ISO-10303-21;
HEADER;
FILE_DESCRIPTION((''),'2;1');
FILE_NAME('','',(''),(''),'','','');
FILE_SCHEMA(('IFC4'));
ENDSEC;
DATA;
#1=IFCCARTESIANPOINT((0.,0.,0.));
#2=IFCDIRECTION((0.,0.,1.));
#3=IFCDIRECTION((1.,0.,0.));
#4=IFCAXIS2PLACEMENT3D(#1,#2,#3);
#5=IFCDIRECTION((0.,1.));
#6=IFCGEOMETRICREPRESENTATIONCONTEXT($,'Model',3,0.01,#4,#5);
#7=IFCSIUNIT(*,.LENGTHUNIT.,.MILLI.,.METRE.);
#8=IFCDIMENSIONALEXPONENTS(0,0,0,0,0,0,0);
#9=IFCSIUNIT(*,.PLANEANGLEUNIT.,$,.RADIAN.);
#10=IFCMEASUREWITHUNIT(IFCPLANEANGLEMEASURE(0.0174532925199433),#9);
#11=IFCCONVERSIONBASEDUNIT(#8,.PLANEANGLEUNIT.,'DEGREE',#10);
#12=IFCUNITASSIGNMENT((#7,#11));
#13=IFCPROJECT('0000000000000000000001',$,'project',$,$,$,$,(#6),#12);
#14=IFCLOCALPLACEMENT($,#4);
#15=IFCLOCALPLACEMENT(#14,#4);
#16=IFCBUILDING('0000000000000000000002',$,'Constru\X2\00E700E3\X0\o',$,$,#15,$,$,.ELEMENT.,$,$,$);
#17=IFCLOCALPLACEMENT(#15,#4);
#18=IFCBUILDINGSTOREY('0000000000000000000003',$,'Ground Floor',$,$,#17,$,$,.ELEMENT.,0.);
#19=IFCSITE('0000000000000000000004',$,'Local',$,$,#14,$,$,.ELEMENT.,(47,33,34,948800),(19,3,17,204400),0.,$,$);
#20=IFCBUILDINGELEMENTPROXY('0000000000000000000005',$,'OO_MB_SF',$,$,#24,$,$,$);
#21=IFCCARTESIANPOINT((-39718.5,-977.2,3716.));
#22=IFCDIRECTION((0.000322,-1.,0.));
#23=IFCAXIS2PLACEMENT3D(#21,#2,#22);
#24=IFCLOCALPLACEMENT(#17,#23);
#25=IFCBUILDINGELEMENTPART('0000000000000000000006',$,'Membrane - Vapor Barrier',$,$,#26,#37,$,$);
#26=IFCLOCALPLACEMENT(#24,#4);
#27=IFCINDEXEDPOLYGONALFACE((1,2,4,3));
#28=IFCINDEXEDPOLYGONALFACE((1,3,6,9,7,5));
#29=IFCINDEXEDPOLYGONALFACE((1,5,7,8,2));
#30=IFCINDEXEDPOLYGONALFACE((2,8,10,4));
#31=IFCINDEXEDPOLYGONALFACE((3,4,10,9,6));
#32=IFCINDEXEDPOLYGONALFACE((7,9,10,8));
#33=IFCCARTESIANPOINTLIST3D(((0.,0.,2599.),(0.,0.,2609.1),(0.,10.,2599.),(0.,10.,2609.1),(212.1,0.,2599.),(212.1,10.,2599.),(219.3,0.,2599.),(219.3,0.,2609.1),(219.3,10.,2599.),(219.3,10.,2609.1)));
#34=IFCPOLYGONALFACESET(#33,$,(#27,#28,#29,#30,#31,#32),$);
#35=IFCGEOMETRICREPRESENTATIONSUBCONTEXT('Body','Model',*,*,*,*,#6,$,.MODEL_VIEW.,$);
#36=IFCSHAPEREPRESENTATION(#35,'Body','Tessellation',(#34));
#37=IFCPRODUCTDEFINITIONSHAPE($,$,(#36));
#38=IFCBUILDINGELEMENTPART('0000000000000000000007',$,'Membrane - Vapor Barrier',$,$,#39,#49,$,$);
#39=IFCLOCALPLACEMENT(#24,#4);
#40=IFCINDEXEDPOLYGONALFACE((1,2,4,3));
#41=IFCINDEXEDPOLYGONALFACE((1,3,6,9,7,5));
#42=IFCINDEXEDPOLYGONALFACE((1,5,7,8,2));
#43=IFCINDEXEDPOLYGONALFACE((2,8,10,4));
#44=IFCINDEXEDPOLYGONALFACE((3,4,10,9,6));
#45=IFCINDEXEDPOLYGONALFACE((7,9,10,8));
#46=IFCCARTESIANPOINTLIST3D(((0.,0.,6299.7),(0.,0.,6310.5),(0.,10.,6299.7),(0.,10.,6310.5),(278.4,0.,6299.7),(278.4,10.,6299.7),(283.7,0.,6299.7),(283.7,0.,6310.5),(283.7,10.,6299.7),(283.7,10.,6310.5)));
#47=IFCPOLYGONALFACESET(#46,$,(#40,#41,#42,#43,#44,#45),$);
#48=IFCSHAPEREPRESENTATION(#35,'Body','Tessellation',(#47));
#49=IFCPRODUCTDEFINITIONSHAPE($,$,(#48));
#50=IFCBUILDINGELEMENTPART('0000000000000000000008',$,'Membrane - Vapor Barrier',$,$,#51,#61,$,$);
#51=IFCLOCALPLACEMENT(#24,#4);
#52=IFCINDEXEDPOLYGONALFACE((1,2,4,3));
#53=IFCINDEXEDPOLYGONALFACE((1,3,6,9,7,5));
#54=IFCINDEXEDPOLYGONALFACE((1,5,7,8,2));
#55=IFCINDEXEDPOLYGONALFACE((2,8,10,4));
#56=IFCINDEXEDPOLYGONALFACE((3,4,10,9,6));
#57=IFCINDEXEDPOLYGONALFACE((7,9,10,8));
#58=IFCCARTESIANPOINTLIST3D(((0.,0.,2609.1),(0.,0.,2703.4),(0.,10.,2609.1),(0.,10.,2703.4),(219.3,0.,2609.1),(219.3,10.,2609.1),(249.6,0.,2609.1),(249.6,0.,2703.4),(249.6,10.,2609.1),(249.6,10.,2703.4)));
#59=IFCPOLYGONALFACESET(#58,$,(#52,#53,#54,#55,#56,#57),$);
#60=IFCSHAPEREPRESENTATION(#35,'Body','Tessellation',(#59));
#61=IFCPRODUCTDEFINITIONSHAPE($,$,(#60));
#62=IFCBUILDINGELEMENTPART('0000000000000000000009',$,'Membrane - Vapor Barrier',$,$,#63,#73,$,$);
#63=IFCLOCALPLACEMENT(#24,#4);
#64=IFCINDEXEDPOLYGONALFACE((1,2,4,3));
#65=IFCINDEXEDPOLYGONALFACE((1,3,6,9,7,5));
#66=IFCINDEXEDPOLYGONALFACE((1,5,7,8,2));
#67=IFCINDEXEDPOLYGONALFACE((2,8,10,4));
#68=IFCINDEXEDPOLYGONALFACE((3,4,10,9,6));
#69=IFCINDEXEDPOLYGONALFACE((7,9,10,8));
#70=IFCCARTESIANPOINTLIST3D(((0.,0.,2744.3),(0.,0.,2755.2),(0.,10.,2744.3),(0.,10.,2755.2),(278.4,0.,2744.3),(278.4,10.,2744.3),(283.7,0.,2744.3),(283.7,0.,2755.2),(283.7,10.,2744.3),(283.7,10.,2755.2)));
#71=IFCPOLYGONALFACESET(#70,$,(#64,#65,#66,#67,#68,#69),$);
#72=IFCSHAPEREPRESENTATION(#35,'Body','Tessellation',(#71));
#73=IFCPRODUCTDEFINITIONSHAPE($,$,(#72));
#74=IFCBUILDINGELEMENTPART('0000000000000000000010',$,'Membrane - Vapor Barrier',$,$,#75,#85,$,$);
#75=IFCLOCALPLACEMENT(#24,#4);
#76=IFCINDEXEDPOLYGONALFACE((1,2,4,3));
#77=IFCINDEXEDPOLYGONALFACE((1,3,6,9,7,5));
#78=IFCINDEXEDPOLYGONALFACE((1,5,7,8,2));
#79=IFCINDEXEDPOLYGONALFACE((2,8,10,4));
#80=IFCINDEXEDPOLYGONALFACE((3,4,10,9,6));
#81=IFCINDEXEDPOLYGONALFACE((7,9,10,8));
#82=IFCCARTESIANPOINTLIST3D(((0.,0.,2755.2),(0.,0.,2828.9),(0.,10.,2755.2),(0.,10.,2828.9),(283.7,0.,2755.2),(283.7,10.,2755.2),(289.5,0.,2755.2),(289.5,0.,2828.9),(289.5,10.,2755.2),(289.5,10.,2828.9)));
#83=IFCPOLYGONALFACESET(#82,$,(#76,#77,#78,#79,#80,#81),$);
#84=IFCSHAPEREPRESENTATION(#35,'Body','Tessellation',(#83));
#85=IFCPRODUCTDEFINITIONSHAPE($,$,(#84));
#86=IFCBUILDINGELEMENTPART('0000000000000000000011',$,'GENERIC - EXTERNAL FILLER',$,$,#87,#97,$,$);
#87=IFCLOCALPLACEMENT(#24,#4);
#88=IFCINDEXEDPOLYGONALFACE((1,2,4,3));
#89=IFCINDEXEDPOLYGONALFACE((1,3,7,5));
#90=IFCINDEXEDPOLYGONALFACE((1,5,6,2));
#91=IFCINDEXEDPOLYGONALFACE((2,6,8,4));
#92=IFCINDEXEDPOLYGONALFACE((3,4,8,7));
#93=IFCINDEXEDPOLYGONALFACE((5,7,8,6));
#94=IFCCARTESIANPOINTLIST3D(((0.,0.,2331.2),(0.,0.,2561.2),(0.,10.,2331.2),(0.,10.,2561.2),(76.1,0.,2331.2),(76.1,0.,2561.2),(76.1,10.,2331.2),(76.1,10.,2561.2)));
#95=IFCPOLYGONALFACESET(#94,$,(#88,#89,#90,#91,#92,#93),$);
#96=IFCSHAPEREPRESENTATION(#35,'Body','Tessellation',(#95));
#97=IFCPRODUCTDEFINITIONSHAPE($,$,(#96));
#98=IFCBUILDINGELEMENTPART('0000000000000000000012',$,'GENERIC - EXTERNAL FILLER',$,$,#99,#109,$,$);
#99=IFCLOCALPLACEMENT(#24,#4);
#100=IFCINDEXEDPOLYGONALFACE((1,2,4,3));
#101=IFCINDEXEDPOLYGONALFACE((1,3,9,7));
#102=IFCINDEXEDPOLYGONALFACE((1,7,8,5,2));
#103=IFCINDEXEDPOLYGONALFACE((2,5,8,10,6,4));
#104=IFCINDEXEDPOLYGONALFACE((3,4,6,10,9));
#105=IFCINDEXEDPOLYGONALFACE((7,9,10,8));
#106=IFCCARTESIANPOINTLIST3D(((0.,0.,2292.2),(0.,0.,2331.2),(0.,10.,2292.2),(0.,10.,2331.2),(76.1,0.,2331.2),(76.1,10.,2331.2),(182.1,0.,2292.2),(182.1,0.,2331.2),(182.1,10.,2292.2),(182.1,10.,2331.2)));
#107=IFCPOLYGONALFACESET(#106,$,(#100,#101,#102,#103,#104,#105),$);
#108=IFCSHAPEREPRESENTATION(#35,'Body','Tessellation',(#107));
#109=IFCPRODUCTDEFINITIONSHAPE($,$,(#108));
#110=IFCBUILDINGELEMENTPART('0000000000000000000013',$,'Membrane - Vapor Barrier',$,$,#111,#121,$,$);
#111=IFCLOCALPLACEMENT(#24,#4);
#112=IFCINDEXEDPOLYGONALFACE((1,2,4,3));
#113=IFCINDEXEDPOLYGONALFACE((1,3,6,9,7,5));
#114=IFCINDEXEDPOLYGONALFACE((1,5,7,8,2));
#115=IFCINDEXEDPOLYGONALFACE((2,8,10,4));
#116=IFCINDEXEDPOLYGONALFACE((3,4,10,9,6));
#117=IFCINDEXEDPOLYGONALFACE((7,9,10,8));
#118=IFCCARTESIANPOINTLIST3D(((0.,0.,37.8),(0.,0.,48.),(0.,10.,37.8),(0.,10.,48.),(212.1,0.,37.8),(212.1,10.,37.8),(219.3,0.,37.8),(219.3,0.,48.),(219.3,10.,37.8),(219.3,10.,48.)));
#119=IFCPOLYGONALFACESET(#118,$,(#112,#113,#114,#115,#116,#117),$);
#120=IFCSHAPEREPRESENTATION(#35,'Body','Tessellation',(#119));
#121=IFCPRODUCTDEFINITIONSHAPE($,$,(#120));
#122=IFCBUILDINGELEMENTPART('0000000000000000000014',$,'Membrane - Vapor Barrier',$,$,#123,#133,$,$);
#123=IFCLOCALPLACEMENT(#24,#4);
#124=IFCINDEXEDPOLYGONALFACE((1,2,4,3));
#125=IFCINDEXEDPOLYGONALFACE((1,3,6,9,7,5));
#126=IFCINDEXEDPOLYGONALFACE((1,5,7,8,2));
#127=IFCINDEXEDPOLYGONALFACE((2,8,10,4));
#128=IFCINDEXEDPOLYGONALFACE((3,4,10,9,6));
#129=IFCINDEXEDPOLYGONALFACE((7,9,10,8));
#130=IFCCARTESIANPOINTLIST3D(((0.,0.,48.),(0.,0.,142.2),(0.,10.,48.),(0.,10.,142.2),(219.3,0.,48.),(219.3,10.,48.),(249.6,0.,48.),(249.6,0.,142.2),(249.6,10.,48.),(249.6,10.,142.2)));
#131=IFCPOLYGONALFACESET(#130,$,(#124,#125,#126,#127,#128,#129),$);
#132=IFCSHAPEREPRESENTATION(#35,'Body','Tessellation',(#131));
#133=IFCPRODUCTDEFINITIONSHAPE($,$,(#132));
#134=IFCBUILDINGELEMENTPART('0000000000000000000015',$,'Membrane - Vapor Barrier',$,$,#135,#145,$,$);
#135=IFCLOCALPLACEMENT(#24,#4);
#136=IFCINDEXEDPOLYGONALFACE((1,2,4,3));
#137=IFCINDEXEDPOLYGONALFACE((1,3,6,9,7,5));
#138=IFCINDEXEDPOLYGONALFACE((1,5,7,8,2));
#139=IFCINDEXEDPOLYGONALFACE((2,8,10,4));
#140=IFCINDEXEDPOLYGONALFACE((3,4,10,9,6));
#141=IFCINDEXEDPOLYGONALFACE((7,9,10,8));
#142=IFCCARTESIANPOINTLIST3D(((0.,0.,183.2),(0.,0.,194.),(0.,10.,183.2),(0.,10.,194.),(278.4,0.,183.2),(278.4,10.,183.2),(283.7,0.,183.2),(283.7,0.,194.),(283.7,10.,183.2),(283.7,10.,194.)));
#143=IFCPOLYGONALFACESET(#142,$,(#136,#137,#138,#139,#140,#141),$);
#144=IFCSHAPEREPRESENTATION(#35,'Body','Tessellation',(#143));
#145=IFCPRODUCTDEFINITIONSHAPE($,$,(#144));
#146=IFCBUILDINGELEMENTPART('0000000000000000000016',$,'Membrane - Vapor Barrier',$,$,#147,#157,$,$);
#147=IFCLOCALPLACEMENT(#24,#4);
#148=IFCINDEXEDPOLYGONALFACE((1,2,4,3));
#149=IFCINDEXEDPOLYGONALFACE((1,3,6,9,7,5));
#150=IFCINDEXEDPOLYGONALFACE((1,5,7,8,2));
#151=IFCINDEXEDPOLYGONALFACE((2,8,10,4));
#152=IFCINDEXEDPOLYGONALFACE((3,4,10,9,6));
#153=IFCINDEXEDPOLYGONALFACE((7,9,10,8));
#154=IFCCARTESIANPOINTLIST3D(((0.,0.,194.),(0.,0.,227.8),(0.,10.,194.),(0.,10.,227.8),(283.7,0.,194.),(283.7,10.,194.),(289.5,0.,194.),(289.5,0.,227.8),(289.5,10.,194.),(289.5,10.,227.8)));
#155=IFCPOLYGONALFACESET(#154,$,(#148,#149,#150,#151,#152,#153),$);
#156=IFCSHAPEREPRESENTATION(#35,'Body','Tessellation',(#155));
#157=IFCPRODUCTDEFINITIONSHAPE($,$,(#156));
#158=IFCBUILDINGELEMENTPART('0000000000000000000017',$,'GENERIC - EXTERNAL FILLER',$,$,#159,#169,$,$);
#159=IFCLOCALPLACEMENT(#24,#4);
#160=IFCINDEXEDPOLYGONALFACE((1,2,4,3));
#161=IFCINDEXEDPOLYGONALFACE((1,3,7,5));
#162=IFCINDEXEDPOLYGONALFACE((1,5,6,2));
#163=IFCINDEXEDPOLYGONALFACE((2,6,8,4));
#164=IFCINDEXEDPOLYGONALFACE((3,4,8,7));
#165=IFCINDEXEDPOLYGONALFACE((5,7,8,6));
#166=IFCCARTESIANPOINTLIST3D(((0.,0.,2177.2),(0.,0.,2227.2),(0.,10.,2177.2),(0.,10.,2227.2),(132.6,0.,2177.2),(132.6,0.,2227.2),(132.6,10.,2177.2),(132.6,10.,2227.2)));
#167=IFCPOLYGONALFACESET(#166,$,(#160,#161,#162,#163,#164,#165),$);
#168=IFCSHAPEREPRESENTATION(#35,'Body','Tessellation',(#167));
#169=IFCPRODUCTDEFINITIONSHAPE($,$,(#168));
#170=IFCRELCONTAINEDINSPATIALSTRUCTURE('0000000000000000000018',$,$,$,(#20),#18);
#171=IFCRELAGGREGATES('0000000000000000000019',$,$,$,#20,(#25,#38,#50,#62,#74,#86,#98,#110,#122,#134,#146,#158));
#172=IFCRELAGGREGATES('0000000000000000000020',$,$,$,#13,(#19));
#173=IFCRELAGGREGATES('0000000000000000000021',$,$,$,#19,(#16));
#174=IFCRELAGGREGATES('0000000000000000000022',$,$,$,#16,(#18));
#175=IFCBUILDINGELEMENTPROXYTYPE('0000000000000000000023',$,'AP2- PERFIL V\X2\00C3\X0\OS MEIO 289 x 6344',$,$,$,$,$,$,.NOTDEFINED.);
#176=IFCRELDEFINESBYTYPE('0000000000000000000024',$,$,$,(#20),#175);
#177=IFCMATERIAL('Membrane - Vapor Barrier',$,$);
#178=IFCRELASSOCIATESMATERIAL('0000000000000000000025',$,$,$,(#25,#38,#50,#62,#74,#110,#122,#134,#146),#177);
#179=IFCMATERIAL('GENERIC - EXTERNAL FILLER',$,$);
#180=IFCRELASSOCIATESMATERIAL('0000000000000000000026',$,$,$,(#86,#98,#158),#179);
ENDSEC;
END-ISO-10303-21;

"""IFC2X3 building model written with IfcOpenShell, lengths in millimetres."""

from ifc_helpers import new_model, entity, si_unit, converted_unit, direction, frame, origin_with_axes, place, context, subcontext, project, spatial, polyline, outline, extrude, material, type_object, element, aggregate, save


model = new_model("IFC2X3")

# Units and contexts
model_context = context("Model", 3, precision=0.01, world=origin_with_axes(), true_north=direction((0.0, 1.0)))
body_context = subcontext(model_context, "Body", "Model", "MODEL_VIEW")
ifc_project = project(units=[si_unit("LENGTHUNIT", "METRE", prefix="MILLI"), converted_unit("PLANEANGLEUNIT", "DEGREE", entity("IfcPlaneAngleMeasure", 0.0174532925199433), si_unit("PLANEANGLEUNIT", "RADIAN"), dimensions=[0, 0, 0, 0, 0, 0, 0])], contexts=[model_context])

# Site, building, storey
site_placement = place(None, origin_with_axes())
site = spatial("IfcSite", under=ifc_project, at=site_placement, Name="Local", CompositionType="ELEMENT", RefLatitude=(47, 33, 34, 948800), RefLongitude=(19, 3, 17, 204400), RefElevation=0.0)
building_placement = place(site_placement, origin_with_axes())
building = spatial("IfcBuilding", under=site, at=building_placement, Name="Construção", CompositionType="ELEMENT")
storey_placement = place(building_placement, origin_with_axes())
storey = spatial("IfcBuildingStorey", under=building, at=storey_placement, Name="Ground Floor", CompositionType="ELEMENT", Elevation=0.0)

# Building element proxy, building element parts
ifc_material_1 = material(Name="GENERIC - EXTERNAL FILLER")
ifc_material_2 = material(Name="Membrane - Vapor Barrier")
building_element_proxy_type_1 = type_object("IfcBuildingElementProxyType", Name="AP2- PERFIL VÃOS MEIO 289 x 6344", PredefinedType="NOTDEFINED")
proxy_1_placement = place(storey_placement, frame((-39718.5, -977.2, 3716.0), z_axis=(0.0, 0.0, 1.0), x_axis=(0.000322, -1.0, 0.0)))
proxy_1 = element("IfcBuildingElementProxy", 1, at=proxy_1_placement, inside=storey, type_object=building_element_proxy_type_1, Name="OO_MB_SF")
building_element_part_1_placement = place(proxy_1_placement, origin_with_axes())
building_element_part_1 = element("IfcBuildingElementPart", 2, at=building_element_part_1_placement, material=ifc_material_2, Name="Membrane - Vapor Barrier", context=body_context, shape_type="SweptSolid", body=[
    extrude(outline(polyline([(0.0, 2599.0), (212.1, 2599.0), (219.3, 2599.0), (219.3, 2609.1), (0.0, 2609.1), (0.0, 2599.0)])), frame((0.0, 10.0, 0.0), z_axis=(0.0, -1.0, 0.0), x_axis=(1.0, 0.0, 0.0)), (0.0, 0.0, 1.0), 10.0),
])
building_element_part_2_placement = place(proxy_1_placement, origin_with_axes())
building_element_part_2 = element("IfcBuildingElementPart", 3, at=building_element_part_2_placement, material=ifc_material_2, Name="Membrane - Vapor Barrier", context=body_context, shape_type="SweptSolid", body=[
    extrude(outline(polyline([(0.0, 6299.7), (278.4, 6299.7), (283.7, 6299.7), (283.7, 6310.5), (0.0, 6310.5), (0.0, 6299.7)])), frame((0.0, 10.0, 0.0), z_axis=(0.0, -1.0, 0.0), x_axis=(1.0, 0.0, 0.0)), (0.0, 0.0, 1.0), 10.0),
])
building_element_part_3_placement = place(proxy_1_placement, origin_with_axes())
building_element_part_3 = element("IfcBuildingElementPart", 4, at=building_element_part_3_placement, material=ifc_material_2, Name="Membrane - Vapor Barrier", context=body_context, shape_type="SweptSolid", body=[
    extrude(outline(polyline([(249.6, 2703.4), (0.0, 2703.4), (0.0, 2609.1), (219.3, 2609.1), (249.6, 2609.1), (249.6, 2703.4)])), frame((0.0, 10.0, 0.0), z_axis=(0.0, -1.0, 0.0), x_axis=(1.0, 0.0, 0.0)), (0.0, 0.0, 1.0), 10.0),
])
building_element_part_4_placement = place(proxy_1_placement, origin_with_axes())
building_element_part_4 = element("IfcBuildingElementPart", 5, at=building_element_part_4_placement, material=ifc_material_2, Name="Membrane - Vapor Barrier", context=body_context, shape_type="SweptSolid", body=[
    extrude(outline(polyline([(0.0, 2744.3), (278.4, 2744.3), (283.7, 2744.3), (283.7, 2755.2), (0.0, 2755.2), (0.0, 2744.3)])), frame((0.0, 10.0, 0.0), z_axis=(0.0, -1.0, 0.0), x_axis=(1.0, 0.0, 0.0)), (0.0, 0.0, 1.0), 10.0),
])
building_element_part_5_placement = place(proxy_1_placement, origin_with_axes())
building_element_part_5 = element("IfcBuildingElementPart", 6, at=building_element_part_5_placement, material=ifc_material_2, Name="Membrane - Vapor Barrier", context=body_context, shape_type="SweptSolid", body=[
    extrude(outline(polyline([(0.0, 2755.2), (283.7, 2755.2), (289.5, 2755.2), (289.5, 2828.9), (0.0, 2828.9), (0.0, 2755.2)])), frame((0.0, 10.0, 0.0), z_axis=(0.0, -1.0, 0.0), x_axis=(1.0, 0.0, 0.0)), (0.0, 0.0, 1.0), 10.0),
])
building_element_part_6_placement = place(proxy_1_placement, origin_with_axes())
building_element_part_6 = element("IfcBuildingElementPart", 7, at=building_element_part_6_placement, material=ifc_material_1, Name="GENERIC - EXTERNAL FILLER", context=body_context, shape_type="SweptSolid", body=[
    extrude(outline(polyline([(76.1, 2561.2), (0.0, 2561.2), (0.0, 2331.2), (76.1, 2331.2), (76.1, 2561.2)])), frame((0.0, 10.0, 0.0), z_axis=(0.0, -1.0, 0.0), x_axis=(1.0, 0.0, 0.0)), (0.0, 0.0, 1.0), 10.0),
])
building_element_part_7_placement = place(proxy_1_placement, origin_with_axes())
building_element_part_7 = element("IfcBuildingElementPart", 8, at=building_element_part_7_placement, material=ifc_material_1, Name="GENERIC - EXTERNAL FILLER", context=body_context, shape_type="SweptSolid", body=[
    extrude(outline(polyline([(0.0, 2331.2), (0.0, 2292.2), (182.1, 2292.2), (182.1, 2331.2), (76.1, 2331.2), (0.0, 2331.2)])), frame((0.0, 10.0, 0.0), z_axis=(0.0, -1.0, 0.0), x_axis=(1.0, 0.0, 0.0)), (0.0, 0.0, 1.0), 10.0),
])
building_element_part_8_placement = place(proxy_1_placement, origin_with_axes())
building_element_part_8 = element("IfcBuildingElementPart", 9, at=building_element_part_8_placement, material=ifc_material_2, Name="Membrane - Vapor Barrier", context=body_context, shape_type="SweptSolid", body=[
    extrude(outline(polyline([(0.0, 37.8), (212.1, 37.8), (219.3, 37.8), (219.3, 48.0), (0.0, 48.0), (0.0, 37.8)])), frame((0.0, 10.0, 0.0), z_axis=(0.0, -1.0, 0.0), x_axis=(1.0, 0.0, 0.0)), (0.0, 0.0, 1.0), 10.0),
])
building_element_part_9_placement = place(proxy_1_placement, origin_with_axes())
building_element_part_9 = element("IfcBuildingElementPart", 10, at=building_element_part_9_placement, material=ifc_material_2, Name="Membrane - Vapor Barrier", context=body_context, shape_type="SweptSolid", body=[
    extrude(outline(polyline([(249.6, 142.2), (0.0, 142.2), (0.0, 48.0), (219.3, 48.0), (249.6, 48.0), (249.6, 142.2)])), frame((0.0, 10.0, 0.0), z_axis=(0.0, -1.0, 0.0), x_axis=(1.0, 0.0, 0.0)), (0.0, 0.0, 1.0), 10.0),
])
building_element_part_10_placement = place(proxy_1_placement, origin_with_axes())
building_element_part_10 = element("IfcBuildingElementPart", 11, at=building_element_part_10_placement, material=ifc_material_2, Name="Membrane - Vapor Barrier", context=body_context, shape_type="SweptSolid", body=[
    extrude(outline(polyline([(0.0, 183.2), (278.4, 183.2), (283.7, 183.2), (283.7, 194.0), (0.0, 194.0), (0.0, 183.2)])), frame((0.0, 10.0, 0.0), z_axis=(0.0, -1.0, 0.0), x_axis=(1.0, 0.0, 0.0)), (0.0, 0.0, 1.0), 10.0),
])
building_element_part_11_placement = place(proxy_1_placement, origin_with_axes())
building_element_part_11 = element("IfcBuildingElementPart", 12, at=building_element_part_11_placement, material=ifc_material_2, Name="Membrane - Vapor Barrier", context=body_context, shape_type="SweptSolid", body=[
    extrude(outline(polyline([(0.0, 194.0), (283.7, 194.0), (289.5, 194.0), (289.5, 227.8), (0.0, 227.8), (0.0, 194.0)])), frame((0.0, 10.0, 0.0), z_axis=(0.0, -1.0, 0.0), x_axis=(1.0, 0.0, 0.0)), (0.0, 0.0, 1.0), 10.0),
])
building_element_part_12_placement = place(proxy_1_placement, origin_with_axes())
building_element_part_12 = element("IfcBuildingElementPart", 13, at=building_element_part_12_placement, material=ifc_material_1, Name="GENERIC - EXTERNAL FILLER", context=body_context, shape_type="SweptSolid", body=[
    extrude(outline(polyline([(0.0, 2227.2), (0.0, 2177.2), (132.6, 2177.2), (132.6, 2227.2), (0.0, 2227.2)])), frame((0.0, 10.0, 0.0), z_axis=(0.0, -1.0, 0.0), x_axis=(1.0, 0.0, 0.0)), (0.0, 0.0, 1.0), 10.0),
])
aggregate(proxy_1, [building_element_part_1, building_element_part_2, building_element_part_3, building_element_part_4, building_element_part_5, building_element_part_6, building_element_part_7, building_element_part_8, building_element_part_9, building_element_part_10, building_element_part_11, building_element_part_12])

save(model, "model.ifc")
